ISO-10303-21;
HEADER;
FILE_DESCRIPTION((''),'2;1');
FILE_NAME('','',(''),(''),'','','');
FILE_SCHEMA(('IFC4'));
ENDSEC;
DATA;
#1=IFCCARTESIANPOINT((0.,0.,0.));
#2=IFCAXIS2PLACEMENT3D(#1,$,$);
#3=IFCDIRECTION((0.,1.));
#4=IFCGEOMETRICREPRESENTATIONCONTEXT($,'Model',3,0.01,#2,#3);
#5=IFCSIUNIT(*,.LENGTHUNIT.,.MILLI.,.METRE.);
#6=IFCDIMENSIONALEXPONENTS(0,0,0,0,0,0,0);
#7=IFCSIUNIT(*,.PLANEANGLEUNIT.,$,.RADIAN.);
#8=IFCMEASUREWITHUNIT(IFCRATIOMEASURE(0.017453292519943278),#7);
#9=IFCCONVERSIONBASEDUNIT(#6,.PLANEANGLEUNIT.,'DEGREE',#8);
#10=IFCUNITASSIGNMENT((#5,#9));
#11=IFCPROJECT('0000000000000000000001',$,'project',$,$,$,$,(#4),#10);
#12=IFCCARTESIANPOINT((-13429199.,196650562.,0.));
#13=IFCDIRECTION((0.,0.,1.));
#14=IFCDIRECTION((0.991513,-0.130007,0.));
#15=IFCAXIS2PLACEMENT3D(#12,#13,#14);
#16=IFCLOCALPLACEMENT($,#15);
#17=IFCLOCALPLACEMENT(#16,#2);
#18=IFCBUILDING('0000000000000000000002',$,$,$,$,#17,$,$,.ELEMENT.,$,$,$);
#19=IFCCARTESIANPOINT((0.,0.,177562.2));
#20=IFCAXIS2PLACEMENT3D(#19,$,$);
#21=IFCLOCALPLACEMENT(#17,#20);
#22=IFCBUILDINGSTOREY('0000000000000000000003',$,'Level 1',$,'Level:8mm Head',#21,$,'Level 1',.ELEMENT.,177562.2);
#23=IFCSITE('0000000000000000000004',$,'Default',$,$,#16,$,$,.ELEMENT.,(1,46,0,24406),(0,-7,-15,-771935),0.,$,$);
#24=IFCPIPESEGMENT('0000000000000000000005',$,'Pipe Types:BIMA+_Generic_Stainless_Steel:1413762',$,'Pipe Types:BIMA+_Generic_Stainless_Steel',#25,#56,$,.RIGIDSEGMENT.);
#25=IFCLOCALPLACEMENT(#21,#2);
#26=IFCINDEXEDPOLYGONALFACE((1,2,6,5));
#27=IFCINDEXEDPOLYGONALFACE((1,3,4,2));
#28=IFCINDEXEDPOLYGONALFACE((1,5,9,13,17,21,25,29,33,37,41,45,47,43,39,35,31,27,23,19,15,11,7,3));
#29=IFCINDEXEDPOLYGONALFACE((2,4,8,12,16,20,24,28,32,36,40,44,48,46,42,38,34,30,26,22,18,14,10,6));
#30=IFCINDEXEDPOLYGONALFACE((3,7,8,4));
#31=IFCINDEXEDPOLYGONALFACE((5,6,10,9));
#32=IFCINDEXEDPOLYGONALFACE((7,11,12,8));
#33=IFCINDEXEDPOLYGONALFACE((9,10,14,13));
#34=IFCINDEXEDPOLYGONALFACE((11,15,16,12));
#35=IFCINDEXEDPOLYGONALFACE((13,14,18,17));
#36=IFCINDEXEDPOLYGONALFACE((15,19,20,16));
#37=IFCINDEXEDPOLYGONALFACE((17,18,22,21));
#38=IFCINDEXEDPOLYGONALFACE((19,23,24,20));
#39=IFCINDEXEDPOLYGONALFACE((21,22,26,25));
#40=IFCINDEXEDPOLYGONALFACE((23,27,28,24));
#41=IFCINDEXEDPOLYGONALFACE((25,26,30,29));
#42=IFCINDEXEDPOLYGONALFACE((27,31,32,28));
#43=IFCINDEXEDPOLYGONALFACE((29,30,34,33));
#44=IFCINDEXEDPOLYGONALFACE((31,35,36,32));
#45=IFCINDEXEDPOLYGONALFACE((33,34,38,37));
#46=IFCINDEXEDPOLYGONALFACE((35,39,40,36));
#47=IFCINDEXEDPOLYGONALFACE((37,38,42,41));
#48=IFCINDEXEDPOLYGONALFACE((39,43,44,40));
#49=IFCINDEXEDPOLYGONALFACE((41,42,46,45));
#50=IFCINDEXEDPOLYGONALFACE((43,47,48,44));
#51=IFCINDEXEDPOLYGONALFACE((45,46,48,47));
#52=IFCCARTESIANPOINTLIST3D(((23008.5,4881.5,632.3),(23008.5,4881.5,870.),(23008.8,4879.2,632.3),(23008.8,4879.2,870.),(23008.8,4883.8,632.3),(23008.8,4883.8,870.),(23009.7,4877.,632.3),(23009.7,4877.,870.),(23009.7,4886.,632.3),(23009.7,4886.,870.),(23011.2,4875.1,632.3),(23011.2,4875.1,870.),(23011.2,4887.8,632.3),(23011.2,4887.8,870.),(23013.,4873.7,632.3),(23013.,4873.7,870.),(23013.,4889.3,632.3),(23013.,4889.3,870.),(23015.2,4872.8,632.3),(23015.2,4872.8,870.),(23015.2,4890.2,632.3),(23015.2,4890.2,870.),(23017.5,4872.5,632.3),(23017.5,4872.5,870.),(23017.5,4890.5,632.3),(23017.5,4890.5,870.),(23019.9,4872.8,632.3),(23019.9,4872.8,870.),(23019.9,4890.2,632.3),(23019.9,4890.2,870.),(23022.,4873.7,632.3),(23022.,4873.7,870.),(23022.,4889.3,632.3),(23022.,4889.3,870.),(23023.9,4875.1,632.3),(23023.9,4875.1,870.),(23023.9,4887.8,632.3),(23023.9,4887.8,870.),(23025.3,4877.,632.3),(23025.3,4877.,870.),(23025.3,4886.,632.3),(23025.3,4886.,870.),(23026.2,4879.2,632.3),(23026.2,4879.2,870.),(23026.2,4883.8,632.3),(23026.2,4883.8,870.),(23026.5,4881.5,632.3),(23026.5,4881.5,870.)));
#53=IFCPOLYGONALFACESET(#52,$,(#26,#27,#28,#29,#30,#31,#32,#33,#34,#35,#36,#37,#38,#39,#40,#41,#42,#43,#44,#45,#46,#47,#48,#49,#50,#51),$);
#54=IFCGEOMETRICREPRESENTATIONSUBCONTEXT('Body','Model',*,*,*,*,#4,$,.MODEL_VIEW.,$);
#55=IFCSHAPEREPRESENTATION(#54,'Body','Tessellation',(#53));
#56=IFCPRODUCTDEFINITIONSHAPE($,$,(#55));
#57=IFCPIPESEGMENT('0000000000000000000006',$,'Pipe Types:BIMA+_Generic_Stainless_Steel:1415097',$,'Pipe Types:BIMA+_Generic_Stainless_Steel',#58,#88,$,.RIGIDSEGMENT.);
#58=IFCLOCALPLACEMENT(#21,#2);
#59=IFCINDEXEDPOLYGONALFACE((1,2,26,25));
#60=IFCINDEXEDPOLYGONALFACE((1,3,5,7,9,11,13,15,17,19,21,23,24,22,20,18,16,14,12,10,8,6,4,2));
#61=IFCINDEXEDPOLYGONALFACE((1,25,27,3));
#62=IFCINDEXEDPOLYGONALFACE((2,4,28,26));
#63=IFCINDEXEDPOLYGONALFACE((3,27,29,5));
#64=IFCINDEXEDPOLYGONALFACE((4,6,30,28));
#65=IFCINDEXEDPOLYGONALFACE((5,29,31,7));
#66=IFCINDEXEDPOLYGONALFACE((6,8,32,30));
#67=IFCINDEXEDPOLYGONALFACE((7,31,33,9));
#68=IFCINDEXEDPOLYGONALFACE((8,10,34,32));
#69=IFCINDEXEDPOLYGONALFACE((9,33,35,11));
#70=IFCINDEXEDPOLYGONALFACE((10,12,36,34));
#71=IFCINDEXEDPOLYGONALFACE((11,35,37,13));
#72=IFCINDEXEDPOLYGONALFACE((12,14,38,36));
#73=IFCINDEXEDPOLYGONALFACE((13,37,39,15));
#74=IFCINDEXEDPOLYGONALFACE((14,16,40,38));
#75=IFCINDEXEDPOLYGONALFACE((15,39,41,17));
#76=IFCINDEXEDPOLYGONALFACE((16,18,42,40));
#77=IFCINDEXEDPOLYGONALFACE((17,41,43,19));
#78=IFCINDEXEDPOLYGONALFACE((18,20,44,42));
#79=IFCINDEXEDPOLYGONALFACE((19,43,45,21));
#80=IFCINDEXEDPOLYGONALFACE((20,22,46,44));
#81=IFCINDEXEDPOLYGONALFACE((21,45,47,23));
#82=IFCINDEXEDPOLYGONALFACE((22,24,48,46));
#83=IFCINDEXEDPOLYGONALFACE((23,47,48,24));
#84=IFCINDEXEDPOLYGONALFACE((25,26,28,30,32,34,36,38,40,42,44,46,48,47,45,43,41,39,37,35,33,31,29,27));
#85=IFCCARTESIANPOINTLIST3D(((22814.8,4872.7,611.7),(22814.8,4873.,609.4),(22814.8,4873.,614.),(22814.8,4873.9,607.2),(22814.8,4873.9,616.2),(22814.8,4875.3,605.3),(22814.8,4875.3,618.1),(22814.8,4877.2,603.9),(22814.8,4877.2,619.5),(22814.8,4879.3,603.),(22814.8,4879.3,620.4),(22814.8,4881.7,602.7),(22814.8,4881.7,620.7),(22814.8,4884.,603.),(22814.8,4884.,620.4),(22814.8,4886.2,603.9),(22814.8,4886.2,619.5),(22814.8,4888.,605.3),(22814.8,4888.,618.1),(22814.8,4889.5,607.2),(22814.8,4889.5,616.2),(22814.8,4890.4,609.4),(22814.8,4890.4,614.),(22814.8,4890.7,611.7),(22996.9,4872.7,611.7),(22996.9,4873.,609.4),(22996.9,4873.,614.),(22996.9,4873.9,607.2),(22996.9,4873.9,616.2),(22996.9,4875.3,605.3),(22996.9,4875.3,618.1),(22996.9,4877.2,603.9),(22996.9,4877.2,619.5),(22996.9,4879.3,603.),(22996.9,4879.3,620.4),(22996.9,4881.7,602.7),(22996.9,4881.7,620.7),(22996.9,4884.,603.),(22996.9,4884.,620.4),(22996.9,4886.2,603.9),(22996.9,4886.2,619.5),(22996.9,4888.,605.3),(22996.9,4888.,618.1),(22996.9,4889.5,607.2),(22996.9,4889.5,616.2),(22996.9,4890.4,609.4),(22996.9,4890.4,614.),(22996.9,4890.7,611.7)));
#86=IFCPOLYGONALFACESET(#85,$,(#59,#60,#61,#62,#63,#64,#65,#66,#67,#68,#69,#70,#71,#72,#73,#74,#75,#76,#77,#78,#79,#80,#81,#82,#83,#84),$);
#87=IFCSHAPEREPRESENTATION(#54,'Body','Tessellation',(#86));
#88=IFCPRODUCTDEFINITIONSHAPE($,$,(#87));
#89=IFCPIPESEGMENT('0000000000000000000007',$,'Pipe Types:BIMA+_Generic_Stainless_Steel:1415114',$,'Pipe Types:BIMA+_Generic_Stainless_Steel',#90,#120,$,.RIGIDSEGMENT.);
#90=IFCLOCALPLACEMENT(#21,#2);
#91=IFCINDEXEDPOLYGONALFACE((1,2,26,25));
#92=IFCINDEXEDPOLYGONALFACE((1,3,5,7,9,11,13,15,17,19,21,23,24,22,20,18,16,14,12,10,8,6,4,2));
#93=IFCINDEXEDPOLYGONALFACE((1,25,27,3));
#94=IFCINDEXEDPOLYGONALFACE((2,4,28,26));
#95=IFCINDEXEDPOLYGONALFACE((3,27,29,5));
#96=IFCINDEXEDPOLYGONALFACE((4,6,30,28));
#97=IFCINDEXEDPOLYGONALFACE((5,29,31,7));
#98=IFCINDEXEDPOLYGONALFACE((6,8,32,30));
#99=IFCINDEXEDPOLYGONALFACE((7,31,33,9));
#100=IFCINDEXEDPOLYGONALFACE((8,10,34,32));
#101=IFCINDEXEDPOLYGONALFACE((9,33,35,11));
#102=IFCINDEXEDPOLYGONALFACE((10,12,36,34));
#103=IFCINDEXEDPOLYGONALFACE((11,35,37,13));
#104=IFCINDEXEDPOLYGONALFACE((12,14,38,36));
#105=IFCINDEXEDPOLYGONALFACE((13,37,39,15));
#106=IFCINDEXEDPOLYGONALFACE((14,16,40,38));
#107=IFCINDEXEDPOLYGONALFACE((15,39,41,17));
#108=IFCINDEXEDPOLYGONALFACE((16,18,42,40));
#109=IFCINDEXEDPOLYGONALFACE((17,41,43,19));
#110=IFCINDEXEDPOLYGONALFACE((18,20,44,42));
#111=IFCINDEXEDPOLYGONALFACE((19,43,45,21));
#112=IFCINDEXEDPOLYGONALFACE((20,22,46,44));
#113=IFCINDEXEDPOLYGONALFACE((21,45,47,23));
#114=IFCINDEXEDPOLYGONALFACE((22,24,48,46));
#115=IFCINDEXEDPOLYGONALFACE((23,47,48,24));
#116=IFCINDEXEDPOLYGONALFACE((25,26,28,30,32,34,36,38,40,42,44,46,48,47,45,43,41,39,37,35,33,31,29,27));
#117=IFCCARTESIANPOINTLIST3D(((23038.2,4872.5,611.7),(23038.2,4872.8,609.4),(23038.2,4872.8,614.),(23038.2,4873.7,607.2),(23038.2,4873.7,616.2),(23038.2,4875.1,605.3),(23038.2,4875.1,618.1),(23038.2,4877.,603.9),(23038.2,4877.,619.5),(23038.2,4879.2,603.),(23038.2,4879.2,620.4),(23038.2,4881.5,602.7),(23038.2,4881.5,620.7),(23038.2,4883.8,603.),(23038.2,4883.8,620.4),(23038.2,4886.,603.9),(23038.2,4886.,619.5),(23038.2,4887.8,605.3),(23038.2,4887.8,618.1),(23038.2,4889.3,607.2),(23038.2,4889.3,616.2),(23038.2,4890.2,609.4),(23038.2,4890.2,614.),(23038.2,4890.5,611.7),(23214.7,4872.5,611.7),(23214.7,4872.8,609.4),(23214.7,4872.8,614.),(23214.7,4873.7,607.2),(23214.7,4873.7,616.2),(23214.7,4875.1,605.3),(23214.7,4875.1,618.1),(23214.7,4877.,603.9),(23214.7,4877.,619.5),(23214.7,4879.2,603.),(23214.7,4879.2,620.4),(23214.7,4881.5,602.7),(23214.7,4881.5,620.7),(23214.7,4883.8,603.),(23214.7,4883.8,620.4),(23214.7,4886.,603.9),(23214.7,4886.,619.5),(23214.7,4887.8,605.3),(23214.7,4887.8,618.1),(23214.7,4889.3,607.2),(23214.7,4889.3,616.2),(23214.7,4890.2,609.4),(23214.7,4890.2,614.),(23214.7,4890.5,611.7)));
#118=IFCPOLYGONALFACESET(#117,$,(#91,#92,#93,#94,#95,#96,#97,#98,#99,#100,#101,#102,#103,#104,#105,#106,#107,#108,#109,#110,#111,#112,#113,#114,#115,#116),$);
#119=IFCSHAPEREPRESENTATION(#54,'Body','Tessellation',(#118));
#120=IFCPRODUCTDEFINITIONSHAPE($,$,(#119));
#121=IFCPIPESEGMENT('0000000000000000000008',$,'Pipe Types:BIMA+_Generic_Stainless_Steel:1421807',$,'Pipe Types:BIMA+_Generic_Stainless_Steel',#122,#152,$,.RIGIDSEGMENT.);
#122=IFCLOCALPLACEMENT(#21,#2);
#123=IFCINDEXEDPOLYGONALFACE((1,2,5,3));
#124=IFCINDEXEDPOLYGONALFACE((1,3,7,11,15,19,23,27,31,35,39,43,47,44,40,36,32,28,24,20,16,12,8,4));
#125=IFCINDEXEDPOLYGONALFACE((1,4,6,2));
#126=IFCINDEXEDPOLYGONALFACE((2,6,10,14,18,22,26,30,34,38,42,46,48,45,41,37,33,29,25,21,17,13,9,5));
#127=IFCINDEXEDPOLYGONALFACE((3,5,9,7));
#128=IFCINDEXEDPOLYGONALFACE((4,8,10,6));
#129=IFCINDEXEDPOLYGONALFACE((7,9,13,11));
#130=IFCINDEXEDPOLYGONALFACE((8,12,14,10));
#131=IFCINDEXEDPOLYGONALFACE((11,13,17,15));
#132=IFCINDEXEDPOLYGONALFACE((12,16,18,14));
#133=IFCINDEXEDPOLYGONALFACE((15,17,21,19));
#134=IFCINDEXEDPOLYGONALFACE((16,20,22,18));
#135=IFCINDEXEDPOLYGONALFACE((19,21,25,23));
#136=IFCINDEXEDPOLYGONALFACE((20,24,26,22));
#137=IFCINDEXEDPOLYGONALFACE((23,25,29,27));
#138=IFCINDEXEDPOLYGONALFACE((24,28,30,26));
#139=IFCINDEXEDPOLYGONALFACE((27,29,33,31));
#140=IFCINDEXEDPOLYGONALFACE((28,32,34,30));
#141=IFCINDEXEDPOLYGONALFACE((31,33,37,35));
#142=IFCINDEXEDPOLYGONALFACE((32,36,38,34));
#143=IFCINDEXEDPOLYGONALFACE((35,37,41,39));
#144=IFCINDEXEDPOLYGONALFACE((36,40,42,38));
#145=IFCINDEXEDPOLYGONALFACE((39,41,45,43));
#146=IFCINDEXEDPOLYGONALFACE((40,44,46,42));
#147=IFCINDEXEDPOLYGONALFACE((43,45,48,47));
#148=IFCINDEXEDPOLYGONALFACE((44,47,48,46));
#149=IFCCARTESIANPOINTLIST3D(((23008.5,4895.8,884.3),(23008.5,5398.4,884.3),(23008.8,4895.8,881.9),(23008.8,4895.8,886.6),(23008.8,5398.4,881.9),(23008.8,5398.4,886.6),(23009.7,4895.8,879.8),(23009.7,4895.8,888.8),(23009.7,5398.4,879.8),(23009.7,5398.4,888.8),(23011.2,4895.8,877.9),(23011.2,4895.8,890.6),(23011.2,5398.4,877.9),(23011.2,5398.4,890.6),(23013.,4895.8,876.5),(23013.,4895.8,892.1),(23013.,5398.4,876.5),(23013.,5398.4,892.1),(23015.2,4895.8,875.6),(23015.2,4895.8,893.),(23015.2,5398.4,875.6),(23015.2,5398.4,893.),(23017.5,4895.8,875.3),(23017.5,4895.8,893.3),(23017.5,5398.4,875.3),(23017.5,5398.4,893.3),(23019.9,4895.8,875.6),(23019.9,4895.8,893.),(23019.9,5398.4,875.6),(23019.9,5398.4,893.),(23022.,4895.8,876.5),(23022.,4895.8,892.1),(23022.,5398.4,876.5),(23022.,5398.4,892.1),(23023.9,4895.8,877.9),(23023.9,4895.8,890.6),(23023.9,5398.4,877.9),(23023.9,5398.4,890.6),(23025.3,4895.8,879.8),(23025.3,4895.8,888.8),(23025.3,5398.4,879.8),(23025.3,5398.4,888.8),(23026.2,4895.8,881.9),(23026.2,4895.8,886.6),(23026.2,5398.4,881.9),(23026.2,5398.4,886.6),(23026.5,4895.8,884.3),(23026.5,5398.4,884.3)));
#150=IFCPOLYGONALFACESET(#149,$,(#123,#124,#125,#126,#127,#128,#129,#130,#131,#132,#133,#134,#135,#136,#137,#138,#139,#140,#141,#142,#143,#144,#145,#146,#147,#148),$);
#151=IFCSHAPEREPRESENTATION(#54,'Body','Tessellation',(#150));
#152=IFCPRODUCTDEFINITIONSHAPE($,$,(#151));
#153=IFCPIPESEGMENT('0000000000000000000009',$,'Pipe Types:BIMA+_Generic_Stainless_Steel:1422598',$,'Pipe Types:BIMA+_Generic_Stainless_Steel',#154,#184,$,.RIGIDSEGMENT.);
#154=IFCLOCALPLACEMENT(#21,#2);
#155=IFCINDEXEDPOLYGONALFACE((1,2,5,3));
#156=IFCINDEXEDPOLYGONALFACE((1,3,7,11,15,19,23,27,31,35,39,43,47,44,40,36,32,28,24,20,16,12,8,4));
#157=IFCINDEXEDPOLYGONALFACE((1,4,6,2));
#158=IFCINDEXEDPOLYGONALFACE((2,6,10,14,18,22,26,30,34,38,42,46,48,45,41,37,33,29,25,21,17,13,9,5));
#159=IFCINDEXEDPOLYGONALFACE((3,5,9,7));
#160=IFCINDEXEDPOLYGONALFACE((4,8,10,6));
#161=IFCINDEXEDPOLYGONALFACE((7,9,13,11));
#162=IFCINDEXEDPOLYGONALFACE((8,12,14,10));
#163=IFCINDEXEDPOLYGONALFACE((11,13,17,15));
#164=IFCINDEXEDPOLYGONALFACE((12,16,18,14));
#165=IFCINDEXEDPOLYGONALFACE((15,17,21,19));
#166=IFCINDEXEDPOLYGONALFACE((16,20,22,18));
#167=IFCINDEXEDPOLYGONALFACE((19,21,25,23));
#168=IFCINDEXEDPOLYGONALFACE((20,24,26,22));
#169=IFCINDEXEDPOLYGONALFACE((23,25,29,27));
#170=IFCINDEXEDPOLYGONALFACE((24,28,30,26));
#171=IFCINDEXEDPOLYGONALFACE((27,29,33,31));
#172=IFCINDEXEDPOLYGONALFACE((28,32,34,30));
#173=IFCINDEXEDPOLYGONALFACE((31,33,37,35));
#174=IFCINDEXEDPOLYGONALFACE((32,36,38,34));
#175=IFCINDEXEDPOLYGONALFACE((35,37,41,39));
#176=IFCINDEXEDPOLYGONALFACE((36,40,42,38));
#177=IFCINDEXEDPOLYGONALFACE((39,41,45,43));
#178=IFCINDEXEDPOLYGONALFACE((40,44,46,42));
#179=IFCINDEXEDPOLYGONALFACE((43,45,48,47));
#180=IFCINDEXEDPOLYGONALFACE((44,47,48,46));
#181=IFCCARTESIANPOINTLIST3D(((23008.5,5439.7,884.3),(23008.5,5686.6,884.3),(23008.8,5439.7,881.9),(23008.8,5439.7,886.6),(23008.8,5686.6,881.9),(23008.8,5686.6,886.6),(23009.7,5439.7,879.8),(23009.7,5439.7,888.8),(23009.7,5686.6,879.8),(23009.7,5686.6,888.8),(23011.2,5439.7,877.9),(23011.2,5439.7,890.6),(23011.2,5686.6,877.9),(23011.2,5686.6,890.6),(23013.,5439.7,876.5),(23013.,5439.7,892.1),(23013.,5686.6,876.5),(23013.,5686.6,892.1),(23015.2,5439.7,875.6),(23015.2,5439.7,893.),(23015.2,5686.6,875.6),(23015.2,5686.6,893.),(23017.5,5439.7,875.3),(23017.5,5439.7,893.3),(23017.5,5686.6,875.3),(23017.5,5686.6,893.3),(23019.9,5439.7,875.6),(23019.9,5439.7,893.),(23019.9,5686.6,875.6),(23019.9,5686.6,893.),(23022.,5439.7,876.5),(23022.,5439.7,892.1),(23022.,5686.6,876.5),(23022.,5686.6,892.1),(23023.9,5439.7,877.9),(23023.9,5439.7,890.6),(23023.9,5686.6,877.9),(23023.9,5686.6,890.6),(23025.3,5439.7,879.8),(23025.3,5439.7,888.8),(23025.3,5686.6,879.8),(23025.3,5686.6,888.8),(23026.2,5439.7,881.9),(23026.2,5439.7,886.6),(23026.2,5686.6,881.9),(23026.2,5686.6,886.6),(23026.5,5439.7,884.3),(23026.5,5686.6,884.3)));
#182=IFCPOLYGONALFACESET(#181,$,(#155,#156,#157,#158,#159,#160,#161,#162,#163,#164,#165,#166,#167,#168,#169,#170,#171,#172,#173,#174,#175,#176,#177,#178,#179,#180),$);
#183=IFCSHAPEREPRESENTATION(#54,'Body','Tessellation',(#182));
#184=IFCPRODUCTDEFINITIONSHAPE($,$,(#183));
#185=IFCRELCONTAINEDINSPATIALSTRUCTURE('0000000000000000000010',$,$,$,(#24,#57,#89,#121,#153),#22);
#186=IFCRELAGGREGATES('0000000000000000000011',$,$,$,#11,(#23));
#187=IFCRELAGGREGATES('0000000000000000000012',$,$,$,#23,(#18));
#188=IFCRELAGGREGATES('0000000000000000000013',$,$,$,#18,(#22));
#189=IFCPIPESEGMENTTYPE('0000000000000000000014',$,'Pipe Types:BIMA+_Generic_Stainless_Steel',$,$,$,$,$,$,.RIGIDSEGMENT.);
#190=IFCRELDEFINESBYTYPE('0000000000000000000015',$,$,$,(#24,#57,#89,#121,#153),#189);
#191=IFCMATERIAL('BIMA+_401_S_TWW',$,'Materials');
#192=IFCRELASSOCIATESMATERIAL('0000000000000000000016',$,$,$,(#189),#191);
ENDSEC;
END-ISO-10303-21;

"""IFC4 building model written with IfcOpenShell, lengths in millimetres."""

from ifc_helpers import new_model, entity, si_unit, converted_unit, direction, frame, origin, place, context, subcontext, project, spatial, arc, indexed_curve, outline, extrude, material, type_object, element, save


model = new_model("IFC4")

# Units and contexts
model_context = context("Model", 3, precision=0.01, world=origin(), true_north=direction((0.0, 1.0)))
body_context = subcontext(model_context, "Body", "Model", "MODEL_VIEW")
ifc_project = project(units=[si_unit("LENGTHUNIT", "METRE", prefix="MILLI"), converted_unit("PLANEANGLEUNIT", "DEGREE", entity("IfcRatioMeasure", 0.017453292519943278), si_unit("PLANEANGLEUNIT", "RADIAN"), dimensions=[0, 0, 0, 0, 0, 0, 0])], contexts=[model_context])

# Site, building, storey
site_placement = place(None, frame((-13429199.0, 196650562.0, 0.0), z_axis=(0.0, 0.0, 1.0), x_axis=(0.991513, -0.130007, 0.0)))
site = spatial("IfcSite", under=ifc_project, at=site_placement, Name="Default", CompositionType="ELEMENT", RefLatitude=(1, 46, 0, 24406), RefLongitude=(0, -7, -15, -771935), RefElevation=0.0)
building_placement = place(site_placement, origin())
building = spatial("IfcBuilding", under=site, at=building_placement, CompositionType="ELEMENT")
storey_placement = place(building_placement, frame((0.0, 0.0, 177562.2)))
storey = spatial("IfcBuildingStorey", under=building, at=storey_placement, Name="Level 1", ObjectType="Level:8mm Head", LongName="Level 1", CompositionType="ELEMENT", Elevation=177562.2)

# Pipe segments
ifc_material_1 = material(Name="BIMA+_401_S_TWW", Category="Materials")
pipe_segment_type_1 = type_object("IfcPipeSegmentType", Name="Pipe Types:BIMA+_Generic_Stainless_Steel", PredefinedType="RIGIDSEGMENT", material=ifc_material_1)
pipe_segment_1_placement = place(storey_placement, frame((23006.9, 4870.9, 632.3)))
element("IfcPipeSegment", 1, at=pipe_segment_1_placement, inside=storey, type_object=pipe_segment_type_1, Name="Pipe Types:BIMA+_Generic_Stainless_Steel:1413762", ObjectType="Pipe Types:BIMA+_Generic_Stainless_Steel", PredefinedType="RIGIDSEGMENT", context=body_context, shape_type="SweptSolid", body=[
    extrude(outline(indexed_curve([(9.0, 0.0), (6.4, 6.4), (0.0, 9.0), (-6.4, 6.4), (-9.0, 0.0), (-6.4, -6.4), (0.0, -9.0), (6.4, -6.4)], segments=[arc(1, 2, 3), arc(3, 4, 5), arc(5, 6, 7), arc(7, 8, 1)], self_intersect=False)), frame((10.6, 10.6, 0.0), z_axis=(0.0, 0.0, 1.0), x_axis=(-1.0, 0.0, 0.0)), (0.0, 0.0, 1.0), 237.6),
])
pipe_segment_2_placement = place(storey_placement, frame((22814.8, 4871.1, 601.1)))
element("IfcPipeSegment", 2, at=pipe_segment_2_placement, inside=storey, type_object=pipe_segment_type_1, Name="Pipe Types:BIMA+_Generic_Stainless_Steel:1415097", ObjectType="Pipe Types:BIMA+_Generic_Stainless_Steel", PredefinedType="RIGIDSEGMENT", context=body_context, shape_type="SweptSolid", body=[
    extrude(outline(indexed_curve([(9.0, 0.0), (6.4, 6.4), (0.0, 9.0), (-6.4, 6.4), (-9.0, 0.0), (-6.4, -6.4), (0.0, -9.0), (6.4, -6.4)], segments=[arc(1, 2, 3), arc(3, 4, 5), arc(5, 6, 7), arc(7, 8, 1)], self_intersect=False)), frame((0.0, 10.6, 10.6), z_axis=(1.0, 0.0, 0.0), x_axis=(0.0, 1.0, 0.0)), (0.0, 0.0, 1.0), 182.1),
])
pipe_segment_3_placement = place(storey_placement, frame((23038.2, 4870.9, 601.1)))
element("IfcPipeSegment", 3, at=pipe_segment_3_placement, inside=storey, type_object=pipe_segment_type_1, Name="Pipe Types:BIMA+_Generic_Stainless_Steel:1415114", ObjectType="Pipe Types:BIMA+_Generic_Stainless_Steel", PredefinedType="RIGIDSEGMENT", context=body_context, shape_type="SweptSolid", body=[
    extrude(outline(indexed_curve([(9.0, 0.0), (6.4, 6.4), (0.0, 9.0), (-6.4, 6.4), (-9.0, 0.0), (-6.4, -6.4), (0.0, -9.0), (6.4, -6.4)], segments=[arc(1, 2, 3), arc(3, 4, 5), arc(5, 6, 7), arc(7, 8, 1)], self_intersect=False)), frame((0.0, 10.6, 10.6), z_axis=(1.0, 0.0, 0.0), x_axis=(0.0, 1.0, 0.0)), (0.0, 0.0, 1.0), 176.6),
])
pipe_segment_4_placement = place(storey_placement, frame((23006.9, 4895.8, 873.7)))
element("IfcPipeSegment", 4, at=pipe_segment_4_placement, inside=storey, type_object=pipe_segment_type_1, Name="Pipe Types:BIMA+_Generic_Stainless_Steel:1421807", ObjectType="Pipe Types:BIMA+_Generic_Stainless_Steel", PredefinedType="RIGIDSEGMENT", context=body_context, shape_type="SweptSolid", body=[
    extrude(outline(indexed_curve([(9.0, 0.0), (6.4, 6.4), (0.0, 9.0), (-6.4, 6.4), (-9.0, 0.0), (-6.4, -6.4), (0.0, -9.0), (6.4, -6.4)], segments=[arc(1, 2, 3), arc(3, 4, 5), arc(5, 6, 7), arc(7, 8, 1)], self_intersect=False)), frame((10.6, 0.0, 10.6), z_axis=(0.0, 1.0, 0.0), x_axis=(-1.0, 0.0, 0.0)), (0.0, 0.0, 1.0), 502.6),
])
pipe_segment_5_placement = place(storey_placement, frame((23006.9, 5439.7, 873.7)))
element("IfcPipeSegment", 5, at=pipe_segment_5_placement, inside=storey, type_object=pipe_segment_type_1, Name="Pipe Types:BIMA+_Generic_Stainless_Steel:1422598", ObjectType="Pipe Types:BIMA+_Generic_Stainless_Steel", PredefinedType="RIGIDSEGMENT", context=body_context, shape_type="SweptSolid", body=[
    extrude(outline(indexed_curve([(9.0, 0.0), (6.4, 6.4), (0.0, 9.0), (-6.4, 6.4), (-9.0, 0.0), (-6.4, -6.4), (0.0, -9.0), (6.4, -6.4)], segments=[arc(1, 2, 3), arc(3, 4, 5), arc(5, 6, 7), arc(7, 8, 1)], self_intersect=False)), frame((10.6, 0.0, 10.6), z_axis=(0.0, 1.0, 0.0), x_axis=(-1.0, 0.0, 0.0)), (0.0, 0.0, 1.0), 246.9),
])

save(model, "model.ifc")
